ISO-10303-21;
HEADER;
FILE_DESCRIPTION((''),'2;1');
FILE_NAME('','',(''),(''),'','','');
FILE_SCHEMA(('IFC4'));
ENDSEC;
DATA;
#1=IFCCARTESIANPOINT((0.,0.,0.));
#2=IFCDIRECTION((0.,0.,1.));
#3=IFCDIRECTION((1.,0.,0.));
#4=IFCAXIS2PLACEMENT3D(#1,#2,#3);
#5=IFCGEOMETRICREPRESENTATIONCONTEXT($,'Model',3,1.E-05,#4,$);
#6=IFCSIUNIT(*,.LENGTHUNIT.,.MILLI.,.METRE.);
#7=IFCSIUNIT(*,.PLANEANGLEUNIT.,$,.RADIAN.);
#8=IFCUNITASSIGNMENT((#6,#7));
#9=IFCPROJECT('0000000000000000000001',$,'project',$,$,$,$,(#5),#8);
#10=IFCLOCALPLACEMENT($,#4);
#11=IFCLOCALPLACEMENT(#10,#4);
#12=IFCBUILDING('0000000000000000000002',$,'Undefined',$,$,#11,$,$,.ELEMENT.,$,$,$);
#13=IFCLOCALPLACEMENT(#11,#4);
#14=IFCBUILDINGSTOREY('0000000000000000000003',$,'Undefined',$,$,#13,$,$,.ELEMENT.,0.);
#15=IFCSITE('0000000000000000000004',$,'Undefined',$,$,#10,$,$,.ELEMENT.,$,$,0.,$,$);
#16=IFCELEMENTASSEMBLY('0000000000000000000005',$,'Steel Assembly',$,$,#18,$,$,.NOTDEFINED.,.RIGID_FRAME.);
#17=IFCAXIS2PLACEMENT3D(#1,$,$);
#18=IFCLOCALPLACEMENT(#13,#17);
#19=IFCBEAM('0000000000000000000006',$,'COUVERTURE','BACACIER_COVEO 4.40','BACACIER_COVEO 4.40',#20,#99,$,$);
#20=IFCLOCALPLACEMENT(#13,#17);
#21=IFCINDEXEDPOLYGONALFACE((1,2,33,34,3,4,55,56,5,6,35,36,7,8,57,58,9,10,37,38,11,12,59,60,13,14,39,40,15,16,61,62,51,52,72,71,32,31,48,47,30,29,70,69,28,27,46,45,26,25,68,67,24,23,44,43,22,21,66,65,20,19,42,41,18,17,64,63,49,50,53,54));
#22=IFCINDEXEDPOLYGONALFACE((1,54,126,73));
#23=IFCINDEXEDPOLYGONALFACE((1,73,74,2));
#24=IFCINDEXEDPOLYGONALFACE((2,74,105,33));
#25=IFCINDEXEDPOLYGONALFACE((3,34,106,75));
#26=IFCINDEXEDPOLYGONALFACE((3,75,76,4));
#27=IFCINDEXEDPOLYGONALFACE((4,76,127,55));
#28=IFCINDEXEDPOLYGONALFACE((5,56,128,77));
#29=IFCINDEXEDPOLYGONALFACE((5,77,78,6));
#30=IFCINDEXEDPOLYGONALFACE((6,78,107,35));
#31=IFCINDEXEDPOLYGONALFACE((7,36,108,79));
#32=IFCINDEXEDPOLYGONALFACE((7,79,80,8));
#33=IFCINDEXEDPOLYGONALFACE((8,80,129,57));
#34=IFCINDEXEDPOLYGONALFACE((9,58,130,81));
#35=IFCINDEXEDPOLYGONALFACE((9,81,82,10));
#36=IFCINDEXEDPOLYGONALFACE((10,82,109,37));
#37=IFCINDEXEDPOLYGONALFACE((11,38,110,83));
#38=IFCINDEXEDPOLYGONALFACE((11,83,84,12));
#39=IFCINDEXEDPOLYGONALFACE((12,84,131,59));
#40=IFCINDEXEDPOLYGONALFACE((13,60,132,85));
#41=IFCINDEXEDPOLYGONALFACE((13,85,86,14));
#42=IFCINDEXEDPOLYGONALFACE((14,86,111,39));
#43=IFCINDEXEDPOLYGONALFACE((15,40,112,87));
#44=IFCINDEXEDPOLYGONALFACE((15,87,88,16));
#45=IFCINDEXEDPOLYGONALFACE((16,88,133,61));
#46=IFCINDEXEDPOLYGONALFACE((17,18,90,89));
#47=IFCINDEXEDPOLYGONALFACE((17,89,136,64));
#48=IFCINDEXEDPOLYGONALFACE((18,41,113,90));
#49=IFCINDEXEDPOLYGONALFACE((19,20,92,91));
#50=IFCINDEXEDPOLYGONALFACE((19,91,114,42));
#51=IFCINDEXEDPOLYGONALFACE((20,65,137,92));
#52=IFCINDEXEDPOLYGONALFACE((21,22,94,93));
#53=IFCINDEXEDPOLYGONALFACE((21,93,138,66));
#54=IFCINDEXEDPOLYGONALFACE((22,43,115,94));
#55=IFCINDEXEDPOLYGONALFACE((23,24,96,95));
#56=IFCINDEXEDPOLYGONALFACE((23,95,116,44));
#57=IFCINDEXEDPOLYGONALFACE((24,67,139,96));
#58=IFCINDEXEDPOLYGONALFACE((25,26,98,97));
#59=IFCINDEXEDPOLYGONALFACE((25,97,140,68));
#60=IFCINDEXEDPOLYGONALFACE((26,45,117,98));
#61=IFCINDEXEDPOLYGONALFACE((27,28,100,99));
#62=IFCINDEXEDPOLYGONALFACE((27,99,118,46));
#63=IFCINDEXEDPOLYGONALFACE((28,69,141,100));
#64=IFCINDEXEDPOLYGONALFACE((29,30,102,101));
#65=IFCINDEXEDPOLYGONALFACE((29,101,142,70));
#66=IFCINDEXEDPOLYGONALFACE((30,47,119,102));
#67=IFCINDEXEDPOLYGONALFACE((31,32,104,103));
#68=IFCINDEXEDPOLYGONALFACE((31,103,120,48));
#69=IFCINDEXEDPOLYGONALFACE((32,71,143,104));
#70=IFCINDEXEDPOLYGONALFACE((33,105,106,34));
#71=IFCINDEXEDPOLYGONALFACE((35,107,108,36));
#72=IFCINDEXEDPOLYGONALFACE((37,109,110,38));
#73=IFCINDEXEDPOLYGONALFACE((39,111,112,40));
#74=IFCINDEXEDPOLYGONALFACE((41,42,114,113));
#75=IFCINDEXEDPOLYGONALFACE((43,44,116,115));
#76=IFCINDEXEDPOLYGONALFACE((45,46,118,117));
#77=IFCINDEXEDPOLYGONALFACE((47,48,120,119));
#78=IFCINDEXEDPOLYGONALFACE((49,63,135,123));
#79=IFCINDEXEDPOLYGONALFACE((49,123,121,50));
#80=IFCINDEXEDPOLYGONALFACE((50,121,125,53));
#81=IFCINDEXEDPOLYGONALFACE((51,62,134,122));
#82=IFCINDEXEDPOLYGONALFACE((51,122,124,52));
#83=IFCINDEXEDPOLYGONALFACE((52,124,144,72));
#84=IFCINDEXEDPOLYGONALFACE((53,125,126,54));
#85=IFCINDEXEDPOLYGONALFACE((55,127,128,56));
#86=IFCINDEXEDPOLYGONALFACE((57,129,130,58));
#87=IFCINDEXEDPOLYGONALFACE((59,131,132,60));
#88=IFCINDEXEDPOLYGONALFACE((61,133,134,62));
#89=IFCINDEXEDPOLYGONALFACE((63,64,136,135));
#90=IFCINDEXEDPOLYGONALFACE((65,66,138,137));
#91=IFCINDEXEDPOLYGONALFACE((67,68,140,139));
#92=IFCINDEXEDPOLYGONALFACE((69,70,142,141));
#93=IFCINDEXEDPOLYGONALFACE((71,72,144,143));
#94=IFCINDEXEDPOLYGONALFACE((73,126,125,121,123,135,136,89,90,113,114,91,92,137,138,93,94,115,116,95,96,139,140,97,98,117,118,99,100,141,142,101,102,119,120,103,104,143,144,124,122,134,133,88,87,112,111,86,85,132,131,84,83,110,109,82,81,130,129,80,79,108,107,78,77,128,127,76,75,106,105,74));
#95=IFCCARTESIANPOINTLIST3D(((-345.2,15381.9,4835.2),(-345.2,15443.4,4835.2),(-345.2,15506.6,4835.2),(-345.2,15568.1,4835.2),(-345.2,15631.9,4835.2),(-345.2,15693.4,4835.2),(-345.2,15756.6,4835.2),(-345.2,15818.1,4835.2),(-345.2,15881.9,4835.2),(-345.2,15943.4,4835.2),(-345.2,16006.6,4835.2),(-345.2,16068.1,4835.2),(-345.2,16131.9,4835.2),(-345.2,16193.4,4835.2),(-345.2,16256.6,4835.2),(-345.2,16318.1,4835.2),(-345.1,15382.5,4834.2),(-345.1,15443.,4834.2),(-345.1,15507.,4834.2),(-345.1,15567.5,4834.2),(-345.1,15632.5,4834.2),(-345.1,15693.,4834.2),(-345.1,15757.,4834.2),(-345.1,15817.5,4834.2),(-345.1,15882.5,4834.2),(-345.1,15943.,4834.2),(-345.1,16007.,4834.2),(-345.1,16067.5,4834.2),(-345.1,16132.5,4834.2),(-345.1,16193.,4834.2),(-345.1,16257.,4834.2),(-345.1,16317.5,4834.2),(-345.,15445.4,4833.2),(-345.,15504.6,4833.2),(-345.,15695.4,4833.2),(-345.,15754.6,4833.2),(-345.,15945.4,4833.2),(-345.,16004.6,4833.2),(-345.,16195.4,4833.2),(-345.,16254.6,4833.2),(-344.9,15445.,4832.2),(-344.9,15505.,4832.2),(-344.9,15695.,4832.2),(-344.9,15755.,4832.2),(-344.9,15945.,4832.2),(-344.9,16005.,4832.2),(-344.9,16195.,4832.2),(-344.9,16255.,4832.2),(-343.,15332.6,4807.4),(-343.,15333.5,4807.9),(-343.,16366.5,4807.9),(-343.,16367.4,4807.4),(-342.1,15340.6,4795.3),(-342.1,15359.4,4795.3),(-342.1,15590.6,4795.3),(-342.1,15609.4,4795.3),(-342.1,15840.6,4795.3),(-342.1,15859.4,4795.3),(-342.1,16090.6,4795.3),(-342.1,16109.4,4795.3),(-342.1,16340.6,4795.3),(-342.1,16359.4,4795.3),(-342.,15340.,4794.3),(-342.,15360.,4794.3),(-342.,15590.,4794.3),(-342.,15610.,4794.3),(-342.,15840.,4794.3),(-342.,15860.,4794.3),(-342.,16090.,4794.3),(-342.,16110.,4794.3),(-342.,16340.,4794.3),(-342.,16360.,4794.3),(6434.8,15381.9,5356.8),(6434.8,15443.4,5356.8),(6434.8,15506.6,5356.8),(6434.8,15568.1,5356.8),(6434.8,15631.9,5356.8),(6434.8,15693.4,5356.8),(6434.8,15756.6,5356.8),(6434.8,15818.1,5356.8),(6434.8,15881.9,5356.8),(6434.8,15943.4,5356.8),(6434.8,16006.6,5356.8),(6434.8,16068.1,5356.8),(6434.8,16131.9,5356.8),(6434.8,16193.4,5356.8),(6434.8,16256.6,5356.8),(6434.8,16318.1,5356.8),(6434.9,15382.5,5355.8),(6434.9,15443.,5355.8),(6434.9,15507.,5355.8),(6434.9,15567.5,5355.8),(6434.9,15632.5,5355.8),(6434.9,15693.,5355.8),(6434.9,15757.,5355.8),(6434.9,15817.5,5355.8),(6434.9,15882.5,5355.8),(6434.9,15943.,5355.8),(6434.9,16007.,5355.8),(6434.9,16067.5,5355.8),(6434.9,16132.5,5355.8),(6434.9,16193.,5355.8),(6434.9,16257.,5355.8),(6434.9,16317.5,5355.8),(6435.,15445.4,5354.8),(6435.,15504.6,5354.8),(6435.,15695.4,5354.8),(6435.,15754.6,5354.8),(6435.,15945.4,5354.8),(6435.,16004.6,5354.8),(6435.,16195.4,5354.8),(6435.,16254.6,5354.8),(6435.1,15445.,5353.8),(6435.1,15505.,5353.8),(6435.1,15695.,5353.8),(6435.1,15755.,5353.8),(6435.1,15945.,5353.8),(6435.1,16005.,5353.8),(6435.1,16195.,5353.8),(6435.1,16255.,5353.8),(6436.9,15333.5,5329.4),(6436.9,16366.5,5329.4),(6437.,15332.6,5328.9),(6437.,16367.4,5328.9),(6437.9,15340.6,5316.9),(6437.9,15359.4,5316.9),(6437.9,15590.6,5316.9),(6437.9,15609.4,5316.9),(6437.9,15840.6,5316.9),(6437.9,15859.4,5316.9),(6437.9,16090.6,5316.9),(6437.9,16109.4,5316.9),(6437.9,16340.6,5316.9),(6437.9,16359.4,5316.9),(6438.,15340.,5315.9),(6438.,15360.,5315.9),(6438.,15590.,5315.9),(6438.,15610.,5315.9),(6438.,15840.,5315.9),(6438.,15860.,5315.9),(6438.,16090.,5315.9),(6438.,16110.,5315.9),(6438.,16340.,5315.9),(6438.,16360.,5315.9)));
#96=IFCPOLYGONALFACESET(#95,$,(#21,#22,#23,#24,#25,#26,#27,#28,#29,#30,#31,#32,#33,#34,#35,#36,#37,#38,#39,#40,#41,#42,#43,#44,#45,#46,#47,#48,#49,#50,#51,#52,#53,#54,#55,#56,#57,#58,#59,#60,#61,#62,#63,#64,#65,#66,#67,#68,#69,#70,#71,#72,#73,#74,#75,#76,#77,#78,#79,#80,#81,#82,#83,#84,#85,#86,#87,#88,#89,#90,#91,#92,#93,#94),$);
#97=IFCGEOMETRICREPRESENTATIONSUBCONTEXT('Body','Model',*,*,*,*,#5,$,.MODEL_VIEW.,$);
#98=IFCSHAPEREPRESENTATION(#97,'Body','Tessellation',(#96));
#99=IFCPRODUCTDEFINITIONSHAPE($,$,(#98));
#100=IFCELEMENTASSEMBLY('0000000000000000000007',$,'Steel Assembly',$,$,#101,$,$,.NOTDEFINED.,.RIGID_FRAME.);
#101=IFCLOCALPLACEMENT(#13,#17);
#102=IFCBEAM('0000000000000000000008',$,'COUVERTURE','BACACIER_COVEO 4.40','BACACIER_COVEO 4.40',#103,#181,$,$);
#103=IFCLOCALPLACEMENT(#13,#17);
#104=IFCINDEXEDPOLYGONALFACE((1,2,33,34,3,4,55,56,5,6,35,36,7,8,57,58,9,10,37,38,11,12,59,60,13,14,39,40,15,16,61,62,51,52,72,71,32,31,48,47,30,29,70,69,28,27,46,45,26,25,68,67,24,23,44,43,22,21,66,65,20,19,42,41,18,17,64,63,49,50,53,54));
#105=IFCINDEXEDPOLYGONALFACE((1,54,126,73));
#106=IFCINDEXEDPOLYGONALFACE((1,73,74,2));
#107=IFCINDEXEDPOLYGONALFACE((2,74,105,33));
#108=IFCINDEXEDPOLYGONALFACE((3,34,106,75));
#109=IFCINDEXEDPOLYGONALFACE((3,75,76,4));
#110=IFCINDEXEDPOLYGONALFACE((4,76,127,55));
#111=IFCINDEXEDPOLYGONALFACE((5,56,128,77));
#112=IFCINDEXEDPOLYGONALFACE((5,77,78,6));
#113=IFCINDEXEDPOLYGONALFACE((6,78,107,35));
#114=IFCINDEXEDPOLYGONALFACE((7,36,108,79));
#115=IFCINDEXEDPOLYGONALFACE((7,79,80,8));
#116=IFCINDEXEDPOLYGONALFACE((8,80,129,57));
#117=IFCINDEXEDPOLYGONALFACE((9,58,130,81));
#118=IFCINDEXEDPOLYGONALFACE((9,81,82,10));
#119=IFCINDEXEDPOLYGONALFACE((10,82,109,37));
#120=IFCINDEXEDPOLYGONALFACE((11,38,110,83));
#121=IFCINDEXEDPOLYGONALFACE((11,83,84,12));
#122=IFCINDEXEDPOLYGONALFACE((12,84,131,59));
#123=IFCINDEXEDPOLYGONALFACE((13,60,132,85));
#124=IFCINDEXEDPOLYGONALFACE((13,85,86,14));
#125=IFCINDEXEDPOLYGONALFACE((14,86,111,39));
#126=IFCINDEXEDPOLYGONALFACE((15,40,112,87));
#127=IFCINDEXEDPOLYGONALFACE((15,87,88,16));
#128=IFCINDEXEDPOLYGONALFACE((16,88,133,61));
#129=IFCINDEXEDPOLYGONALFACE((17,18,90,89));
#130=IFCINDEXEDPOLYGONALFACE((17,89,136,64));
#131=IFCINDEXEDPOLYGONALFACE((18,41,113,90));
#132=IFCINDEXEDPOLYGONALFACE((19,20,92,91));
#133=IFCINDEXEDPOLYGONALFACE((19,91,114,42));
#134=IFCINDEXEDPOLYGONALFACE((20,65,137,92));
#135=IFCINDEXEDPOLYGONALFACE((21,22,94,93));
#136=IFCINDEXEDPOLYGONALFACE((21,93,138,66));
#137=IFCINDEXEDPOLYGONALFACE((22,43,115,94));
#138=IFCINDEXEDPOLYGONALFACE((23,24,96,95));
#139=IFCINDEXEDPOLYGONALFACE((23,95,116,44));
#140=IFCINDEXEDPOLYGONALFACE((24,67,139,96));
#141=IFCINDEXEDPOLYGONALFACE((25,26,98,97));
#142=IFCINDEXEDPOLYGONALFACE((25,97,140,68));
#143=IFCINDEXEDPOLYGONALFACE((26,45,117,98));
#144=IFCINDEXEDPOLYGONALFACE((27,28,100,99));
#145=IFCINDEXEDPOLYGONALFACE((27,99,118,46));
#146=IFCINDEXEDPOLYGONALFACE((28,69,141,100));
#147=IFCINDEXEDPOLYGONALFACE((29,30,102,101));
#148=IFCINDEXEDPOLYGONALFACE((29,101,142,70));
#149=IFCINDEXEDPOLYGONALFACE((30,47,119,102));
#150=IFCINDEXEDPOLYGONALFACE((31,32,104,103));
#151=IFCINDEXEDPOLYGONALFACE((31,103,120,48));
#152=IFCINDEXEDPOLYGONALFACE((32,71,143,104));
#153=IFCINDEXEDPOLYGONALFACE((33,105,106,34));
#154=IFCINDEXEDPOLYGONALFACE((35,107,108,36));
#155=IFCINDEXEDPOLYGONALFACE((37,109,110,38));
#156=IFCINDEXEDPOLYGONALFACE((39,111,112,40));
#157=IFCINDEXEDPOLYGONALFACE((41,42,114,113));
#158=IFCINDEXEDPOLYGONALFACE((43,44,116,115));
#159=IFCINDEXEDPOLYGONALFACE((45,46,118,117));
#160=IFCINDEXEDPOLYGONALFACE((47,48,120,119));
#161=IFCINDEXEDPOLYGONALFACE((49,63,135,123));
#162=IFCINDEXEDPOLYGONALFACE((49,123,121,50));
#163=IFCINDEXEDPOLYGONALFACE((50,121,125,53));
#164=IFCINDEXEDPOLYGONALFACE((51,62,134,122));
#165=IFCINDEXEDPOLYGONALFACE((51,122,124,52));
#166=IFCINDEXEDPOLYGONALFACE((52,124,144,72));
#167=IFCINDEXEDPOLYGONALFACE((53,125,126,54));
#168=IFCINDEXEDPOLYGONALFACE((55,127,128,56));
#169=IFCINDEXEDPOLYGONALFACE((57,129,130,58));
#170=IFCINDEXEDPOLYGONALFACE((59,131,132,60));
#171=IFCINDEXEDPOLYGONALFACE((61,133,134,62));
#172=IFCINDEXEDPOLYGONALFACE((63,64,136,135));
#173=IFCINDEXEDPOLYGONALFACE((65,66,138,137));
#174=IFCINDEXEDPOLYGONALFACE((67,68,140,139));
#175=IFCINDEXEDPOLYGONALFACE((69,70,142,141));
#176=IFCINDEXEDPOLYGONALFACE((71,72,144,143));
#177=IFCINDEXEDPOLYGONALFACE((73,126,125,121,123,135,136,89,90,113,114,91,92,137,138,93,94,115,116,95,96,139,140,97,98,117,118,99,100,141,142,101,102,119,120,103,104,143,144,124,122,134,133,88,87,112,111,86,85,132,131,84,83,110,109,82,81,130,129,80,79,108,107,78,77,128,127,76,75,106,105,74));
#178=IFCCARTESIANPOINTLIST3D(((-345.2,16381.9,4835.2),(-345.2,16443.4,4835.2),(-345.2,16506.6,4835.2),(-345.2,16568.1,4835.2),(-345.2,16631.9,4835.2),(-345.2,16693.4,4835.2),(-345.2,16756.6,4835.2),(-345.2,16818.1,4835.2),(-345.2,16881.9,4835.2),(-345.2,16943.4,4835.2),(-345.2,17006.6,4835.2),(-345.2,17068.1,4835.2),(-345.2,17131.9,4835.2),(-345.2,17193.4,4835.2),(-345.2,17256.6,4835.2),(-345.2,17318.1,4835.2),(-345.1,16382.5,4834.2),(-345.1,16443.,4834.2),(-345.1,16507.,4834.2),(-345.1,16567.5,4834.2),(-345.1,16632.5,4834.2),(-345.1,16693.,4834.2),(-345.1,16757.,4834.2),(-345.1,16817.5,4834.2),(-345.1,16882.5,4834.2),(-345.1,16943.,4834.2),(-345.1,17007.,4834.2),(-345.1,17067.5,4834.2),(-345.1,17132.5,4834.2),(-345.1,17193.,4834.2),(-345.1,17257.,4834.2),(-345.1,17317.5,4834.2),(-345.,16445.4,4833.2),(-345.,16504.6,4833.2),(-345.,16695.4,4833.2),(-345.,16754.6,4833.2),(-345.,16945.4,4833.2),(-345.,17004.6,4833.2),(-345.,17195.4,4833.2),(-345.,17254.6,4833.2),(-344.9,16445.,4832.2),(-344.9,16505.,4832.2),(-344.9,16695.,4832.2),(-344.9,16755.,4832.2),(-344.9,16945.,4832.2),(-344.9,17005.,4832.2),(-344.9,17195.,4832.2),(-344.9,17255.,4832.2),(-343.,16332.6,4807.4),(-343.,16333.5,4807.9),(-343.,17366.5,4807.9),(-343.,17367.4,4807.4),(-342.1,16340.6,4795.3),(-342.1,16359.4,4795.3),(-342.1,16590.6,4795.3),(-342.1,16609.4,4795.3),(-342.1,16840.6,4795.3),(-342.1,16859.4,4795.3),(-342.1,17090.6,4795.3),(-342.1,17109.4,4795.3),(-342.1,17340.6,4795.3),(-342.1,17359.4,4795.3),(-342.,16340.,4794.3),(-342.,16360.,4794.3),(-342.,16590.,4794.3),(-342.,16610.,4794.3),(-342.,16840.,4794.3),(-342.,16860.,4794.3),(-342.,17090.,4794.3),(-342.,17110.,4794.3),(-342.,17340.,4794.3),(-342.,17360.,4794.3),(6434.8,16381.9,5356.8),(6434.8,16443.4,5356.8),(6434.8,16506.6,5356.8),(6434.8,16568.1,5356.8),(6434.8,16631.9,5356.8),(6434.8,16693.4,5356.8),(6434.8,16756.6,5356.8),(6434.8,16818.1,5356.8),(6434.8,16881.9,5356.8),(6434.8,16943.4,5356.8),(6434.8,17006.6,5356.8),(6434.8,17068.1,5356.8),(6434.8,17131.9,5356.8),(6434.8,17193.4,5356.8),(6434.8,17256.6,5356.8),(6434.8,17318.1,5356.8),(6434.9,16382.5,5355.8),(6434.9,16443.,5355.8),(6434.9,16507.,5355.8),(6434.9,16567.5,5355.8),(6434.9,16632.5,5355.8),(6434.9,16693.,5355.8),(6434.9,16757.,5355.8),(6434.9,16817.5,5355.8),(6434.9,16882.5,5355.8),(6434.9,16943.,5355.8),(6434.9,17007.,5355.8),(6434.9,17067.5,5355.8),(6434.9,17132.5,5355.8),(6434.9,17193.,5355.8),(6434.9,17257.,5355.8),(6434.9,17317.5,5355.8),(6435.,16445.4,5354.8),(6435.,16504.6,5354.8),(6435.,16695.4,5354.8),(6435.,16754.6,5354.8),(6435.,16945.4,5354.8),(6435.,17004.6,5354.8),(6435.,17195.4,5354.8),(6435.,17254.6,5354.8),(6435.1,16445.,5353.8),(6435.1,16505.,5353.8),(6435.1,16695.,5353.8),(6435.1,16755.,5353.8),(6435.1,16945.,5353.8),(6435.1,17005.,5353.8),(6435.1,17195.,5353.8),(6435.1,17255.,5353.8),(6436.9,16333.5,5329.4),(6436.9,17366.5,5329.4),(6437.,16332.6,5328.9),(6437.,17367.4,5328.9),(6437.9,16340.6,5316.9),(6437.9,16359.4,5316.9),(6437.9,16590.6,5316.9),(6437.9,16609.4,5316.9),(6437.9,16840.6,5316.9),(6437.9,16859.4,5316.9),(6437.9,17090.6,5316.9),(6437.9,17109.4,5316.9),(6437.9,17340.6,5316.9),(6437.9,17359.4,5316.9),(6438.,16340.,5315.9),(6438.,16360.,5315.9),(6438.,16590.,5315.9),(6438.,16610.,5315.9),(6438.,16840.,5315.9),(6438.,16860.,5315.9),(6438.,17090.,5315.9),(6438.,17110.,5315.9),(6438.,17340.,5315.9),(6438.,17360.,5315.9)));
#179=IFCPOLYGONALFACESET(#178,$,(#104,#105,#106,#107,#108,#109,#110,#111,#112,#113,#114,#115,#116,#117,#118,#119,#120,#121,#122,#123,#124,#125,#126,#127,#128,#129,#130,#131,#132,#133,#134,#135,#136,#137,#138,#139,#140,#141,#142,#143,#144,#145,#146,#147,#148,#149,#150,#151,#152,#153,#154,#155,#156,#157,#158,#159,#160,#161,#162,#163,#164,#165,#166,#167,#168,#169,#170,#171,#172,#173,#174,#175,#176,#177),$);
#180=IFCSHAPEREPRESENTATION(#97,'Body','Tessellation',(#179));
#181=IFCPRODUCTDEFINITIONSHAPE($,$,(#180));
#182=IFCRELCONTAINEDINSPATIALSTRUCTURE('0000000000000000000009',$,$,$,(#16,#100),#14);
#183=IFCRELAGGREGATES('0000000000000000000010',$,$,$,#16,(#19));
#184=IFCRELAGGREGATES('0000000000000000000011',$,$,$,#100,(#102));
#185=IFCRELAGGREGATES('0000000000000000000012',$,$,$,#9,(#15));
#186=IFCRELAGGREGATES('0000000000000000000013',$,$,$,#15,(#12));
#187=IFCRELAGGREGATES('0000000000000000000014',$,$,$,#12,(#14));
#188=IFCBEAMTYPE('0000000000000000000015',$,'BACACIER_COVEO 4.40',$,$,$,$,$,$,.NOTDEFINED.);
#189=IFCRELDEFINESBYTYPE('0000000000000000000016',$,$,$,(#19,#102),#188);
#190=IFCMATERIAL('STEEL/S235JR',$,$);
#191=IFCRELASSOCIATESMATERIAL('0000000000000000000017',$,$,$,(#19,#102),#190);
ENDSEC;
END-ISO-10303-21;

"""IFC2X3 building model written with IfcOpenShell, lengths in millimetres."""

from ifc_helpers import new_model, si_unit, frame, origin_with_axes, place, context, subcontext, project, spatial, polyline, outline, extrude, material, type_object, element, aggregate, save


model = new_model("IFC2X3")

# Units and contexts
model_context = context("Model", 3, precision=1e-05, world=origin_with_axes())
body_context = subcontext(model_context, "Body", "Model", "MODEL_VIEW")
ifc_project = project(units=[si_unit("LENGTHUNIT", "METRE", prefix="MILLI"), si_unit("PLANEANGLEUNIT", "RADIAN")], contexts=[model_context])

# Site, building, storey
site_placement = place(None, origin_with_axes())
site = spatial("IfcSite", under=ifc_project, at=site_placement, Name="Undefined", CompositionType="ELEMENT", RefElevation=0.0)
building_placement = place(site_placement, origin_with_axes())
building = spatial("IfcBuilding", under=site, at=building_placement, Name="Undefined", CompositionType="ELEMENT")
storey_placement = place(building_placement, origin_with_axes())
storey = spatial("IfcBuildingStorey", under=building, at=storey_placement, Name="Undefined", CompositionType="ELEMENT", Elevation=0.0)

# Element assemblies, beams
assembly_1_placement = place(storey_placement, origin_with_axes())
assembly_1 = element("IfcElementAssembly", 1, at=assembly_1_placement, inside=storey, Name="Steel Assembly", AssemblyPlace="NOTDEFINED", PredefinedType="RIGID_FRAME")
ifc_material_1 = material(Name="STEEL/S235JR")
beam_type_1 = type_object("IfcBeamType", Name="BACACIER_COVEO 4.40", PredefinedType="NOTDEFINED")
beam_1_placement = place(assembly_1_placement, frame((6436.4, 15850.0, 5336.3), z_axis=(0.076696, 0.0, -0.997054), x_axis=(-0.997054, 0.0, -0.076696)))
beam_1 = element("IfcBeam", 2, at=beam_1_placement, type_object=beam_type_1, material=ifc_material_1, Name="COUVERTURE", Description="BACACIER_COVEO 4.40", ObjectType="BACACIER_COVEO 4.40", context=body_context, shape_type="SweptSolid", body=[
    extrude(outline(polyline([(509.4, 19.5), (490.6, 19.5), (468.1, -20.5), (406.6, -20.5), (404.6, -18.5), (345.4, -18.5), (343.4, -20.5), (281.9, -20.5), (259.4, 19.5), (240.6, 19.5), (218.1, -20.5), (156.6, -20.5), (154.6, -18.5), (95.4, -18.5), (93.4, -20.5), (31.9, -20.5), (9.4, 19.5), (-9.4, 19.5), (-31.9, -20.5), (-93.4, -20.5), (-95.4, -18.5), (-154.6, -18.5), (-156.6, -20.5), (-218.1, -20.5), (-240.6, 19.5), (-259.4, 19.5), (-281.9, -20.5), (-343.4, -20.5), (-345.4, -18.5), (-404.6, -18.5), (-406.6, -20.5), (-468.1, -20.5), (-490.6, 19.5), (-509.4, 19.5), (-516.5, 6.9), (-517.4, 7.4), (-510.0, 20.5), (-490.0, 20.5), (-467.5, -19.5), (-407.0, -19.5), (-405.0, -17.5), (-345.0, -17.5), (-343.0, -19.5), (-282.5, -19.5), (-260.0, 20.5), (-240.0, 20.5), (-217.5, -19.5), (-157.0, -19.5), (-155.0, -17.5), (-95.0, -17.5), (-93.0, -19.5), (-32.5, -19.5), (-10.0, 20.5), (10.0, 20.5), (32.5, -19.5), (93.0, -19.5), (95.0, -17.5), (155.0, -17.5), (157.0, -19.5), (217.5, -19.5), (240.0, 20.5), (260.0, 20.5), (282.5, -19.5), (343.0, -19.5), (345.0, -17.5), (405.0, -17.5), (407.0, -19.5), (467.5, -19.5), (490.0, 20.5), (510.0, 20.5), (517.4, 7.4), (516.5, 6.9), (509.4, 19.5)])), frame((6800.0, 0.0, 0.0), z_axis=(-1.0, 0.0, 0.0), x_axis=(0.0, -1.0, 0.0)), (0.0, 0.0, 1.0), 6800.0),
])
aggregate(assembly_1, [beam_1])
assembly_2_placement = place(storey_placement, origin_with_axes())
assembly_2 = element("IfcElementAssembly", 3, at=assembly_2_placement, inside=storey, Name="Steel Assembly", AssemblyPlace="NOTDEFINED", PredefinedType="RIGID_FRAME")
beam_2_placement = place(assembly_2_placement, frame((6436.4, 16850.0, 5336.3), z_axis=(0.076696, 0.0, -0.997054), x_axis=(-0.997054, 0.0, -0.076696)))
beam_2 = element("IfcBeam", 4, at=beam_2_placement, type_object=beam_type_1, material=ifc_material_1, Name="COUVERTURE", Description="BACACIER_COVEO 4.40", ObjectType="BACACIER_COVEO 4.40", context=body_context, shape_type="SweptSolid", body=[
    extrude(outline(polyline([(509.4, 19.5), (490.6, 19.5), (468.1, -20.5), (406.6, -20.5), (404.6, -18.5), (345.4, -18.5), (343.4, -20.5), (281.9, -20.5), (259.4, 19.5), (240.6, 19.5), (218.1, -20.5), (156.6, -20.5), (154.6, -18.5), (95.4, -18.5), (93.4, -20.5), (31.9, -20.5), (9.4, 19.5), (-9.4, 19.5), (-31.9, -20.5), (-93.4, -20.5), (-95.4, -18.5), (-154.6, -18.5), (-156.6, -20.5), (-218.1, -20.5), (-240.6, 19.5), (-259.4, 19.5), (-281.9, -20.5), (-343.4, -20.5), (-345.4, -18.5), (-404.6, -18.5), (-406.6, -20.5), (-468.1, -20.5), (-490.6, 19.5), (-509.4, 19.5), (-516.5, 6.9), (-517.4, 7.4), (-510.0, 20.5), (-490.0, 20.5), (-467.5, -19.5), (-407.0, -19.5), (-405.0, -17.5), (-345.0, -17.5), (-343.0, -19.5), (-282.5, -19.5), (-260.0, 20.5), (-240.0, 20.5), (-217.5, -19.5), (-157.0, -19.5), (-155.0, -17.5), (-95.0, -17.5), (-93.0, -19.5), (-32.5, -19.5), (-10.0, 20.5), (10.0, 20.5), (32.5, -19.5), (93.0, -19.5), (95.0, -17.5), (155.0, -17.5), (157.0, -19.5), (217.5, -19.5), (240.0, 20.5), (260.0, 20.5), (282.5, -19.5), (343.0, -19.5), (345.0, -17.5), (405.0, -17.5), (407.0, -19.5), (467.5, -19.5), (490.0, 20.5), (510.0, 20.5), (517.4, 7.4), (516.5, 6.9), (509.4, 19.5)])), frame((6800.0, 0.0, 0.0), z_axis=(-1.0, 0.0, 0.0), x_axis=(0.0, -1.0, 0.0)), (0.0, 0.0, 1.0), 6800.0),
])
aggregate(assembly_2, [beam_2])

save(model, "model.ifc")
